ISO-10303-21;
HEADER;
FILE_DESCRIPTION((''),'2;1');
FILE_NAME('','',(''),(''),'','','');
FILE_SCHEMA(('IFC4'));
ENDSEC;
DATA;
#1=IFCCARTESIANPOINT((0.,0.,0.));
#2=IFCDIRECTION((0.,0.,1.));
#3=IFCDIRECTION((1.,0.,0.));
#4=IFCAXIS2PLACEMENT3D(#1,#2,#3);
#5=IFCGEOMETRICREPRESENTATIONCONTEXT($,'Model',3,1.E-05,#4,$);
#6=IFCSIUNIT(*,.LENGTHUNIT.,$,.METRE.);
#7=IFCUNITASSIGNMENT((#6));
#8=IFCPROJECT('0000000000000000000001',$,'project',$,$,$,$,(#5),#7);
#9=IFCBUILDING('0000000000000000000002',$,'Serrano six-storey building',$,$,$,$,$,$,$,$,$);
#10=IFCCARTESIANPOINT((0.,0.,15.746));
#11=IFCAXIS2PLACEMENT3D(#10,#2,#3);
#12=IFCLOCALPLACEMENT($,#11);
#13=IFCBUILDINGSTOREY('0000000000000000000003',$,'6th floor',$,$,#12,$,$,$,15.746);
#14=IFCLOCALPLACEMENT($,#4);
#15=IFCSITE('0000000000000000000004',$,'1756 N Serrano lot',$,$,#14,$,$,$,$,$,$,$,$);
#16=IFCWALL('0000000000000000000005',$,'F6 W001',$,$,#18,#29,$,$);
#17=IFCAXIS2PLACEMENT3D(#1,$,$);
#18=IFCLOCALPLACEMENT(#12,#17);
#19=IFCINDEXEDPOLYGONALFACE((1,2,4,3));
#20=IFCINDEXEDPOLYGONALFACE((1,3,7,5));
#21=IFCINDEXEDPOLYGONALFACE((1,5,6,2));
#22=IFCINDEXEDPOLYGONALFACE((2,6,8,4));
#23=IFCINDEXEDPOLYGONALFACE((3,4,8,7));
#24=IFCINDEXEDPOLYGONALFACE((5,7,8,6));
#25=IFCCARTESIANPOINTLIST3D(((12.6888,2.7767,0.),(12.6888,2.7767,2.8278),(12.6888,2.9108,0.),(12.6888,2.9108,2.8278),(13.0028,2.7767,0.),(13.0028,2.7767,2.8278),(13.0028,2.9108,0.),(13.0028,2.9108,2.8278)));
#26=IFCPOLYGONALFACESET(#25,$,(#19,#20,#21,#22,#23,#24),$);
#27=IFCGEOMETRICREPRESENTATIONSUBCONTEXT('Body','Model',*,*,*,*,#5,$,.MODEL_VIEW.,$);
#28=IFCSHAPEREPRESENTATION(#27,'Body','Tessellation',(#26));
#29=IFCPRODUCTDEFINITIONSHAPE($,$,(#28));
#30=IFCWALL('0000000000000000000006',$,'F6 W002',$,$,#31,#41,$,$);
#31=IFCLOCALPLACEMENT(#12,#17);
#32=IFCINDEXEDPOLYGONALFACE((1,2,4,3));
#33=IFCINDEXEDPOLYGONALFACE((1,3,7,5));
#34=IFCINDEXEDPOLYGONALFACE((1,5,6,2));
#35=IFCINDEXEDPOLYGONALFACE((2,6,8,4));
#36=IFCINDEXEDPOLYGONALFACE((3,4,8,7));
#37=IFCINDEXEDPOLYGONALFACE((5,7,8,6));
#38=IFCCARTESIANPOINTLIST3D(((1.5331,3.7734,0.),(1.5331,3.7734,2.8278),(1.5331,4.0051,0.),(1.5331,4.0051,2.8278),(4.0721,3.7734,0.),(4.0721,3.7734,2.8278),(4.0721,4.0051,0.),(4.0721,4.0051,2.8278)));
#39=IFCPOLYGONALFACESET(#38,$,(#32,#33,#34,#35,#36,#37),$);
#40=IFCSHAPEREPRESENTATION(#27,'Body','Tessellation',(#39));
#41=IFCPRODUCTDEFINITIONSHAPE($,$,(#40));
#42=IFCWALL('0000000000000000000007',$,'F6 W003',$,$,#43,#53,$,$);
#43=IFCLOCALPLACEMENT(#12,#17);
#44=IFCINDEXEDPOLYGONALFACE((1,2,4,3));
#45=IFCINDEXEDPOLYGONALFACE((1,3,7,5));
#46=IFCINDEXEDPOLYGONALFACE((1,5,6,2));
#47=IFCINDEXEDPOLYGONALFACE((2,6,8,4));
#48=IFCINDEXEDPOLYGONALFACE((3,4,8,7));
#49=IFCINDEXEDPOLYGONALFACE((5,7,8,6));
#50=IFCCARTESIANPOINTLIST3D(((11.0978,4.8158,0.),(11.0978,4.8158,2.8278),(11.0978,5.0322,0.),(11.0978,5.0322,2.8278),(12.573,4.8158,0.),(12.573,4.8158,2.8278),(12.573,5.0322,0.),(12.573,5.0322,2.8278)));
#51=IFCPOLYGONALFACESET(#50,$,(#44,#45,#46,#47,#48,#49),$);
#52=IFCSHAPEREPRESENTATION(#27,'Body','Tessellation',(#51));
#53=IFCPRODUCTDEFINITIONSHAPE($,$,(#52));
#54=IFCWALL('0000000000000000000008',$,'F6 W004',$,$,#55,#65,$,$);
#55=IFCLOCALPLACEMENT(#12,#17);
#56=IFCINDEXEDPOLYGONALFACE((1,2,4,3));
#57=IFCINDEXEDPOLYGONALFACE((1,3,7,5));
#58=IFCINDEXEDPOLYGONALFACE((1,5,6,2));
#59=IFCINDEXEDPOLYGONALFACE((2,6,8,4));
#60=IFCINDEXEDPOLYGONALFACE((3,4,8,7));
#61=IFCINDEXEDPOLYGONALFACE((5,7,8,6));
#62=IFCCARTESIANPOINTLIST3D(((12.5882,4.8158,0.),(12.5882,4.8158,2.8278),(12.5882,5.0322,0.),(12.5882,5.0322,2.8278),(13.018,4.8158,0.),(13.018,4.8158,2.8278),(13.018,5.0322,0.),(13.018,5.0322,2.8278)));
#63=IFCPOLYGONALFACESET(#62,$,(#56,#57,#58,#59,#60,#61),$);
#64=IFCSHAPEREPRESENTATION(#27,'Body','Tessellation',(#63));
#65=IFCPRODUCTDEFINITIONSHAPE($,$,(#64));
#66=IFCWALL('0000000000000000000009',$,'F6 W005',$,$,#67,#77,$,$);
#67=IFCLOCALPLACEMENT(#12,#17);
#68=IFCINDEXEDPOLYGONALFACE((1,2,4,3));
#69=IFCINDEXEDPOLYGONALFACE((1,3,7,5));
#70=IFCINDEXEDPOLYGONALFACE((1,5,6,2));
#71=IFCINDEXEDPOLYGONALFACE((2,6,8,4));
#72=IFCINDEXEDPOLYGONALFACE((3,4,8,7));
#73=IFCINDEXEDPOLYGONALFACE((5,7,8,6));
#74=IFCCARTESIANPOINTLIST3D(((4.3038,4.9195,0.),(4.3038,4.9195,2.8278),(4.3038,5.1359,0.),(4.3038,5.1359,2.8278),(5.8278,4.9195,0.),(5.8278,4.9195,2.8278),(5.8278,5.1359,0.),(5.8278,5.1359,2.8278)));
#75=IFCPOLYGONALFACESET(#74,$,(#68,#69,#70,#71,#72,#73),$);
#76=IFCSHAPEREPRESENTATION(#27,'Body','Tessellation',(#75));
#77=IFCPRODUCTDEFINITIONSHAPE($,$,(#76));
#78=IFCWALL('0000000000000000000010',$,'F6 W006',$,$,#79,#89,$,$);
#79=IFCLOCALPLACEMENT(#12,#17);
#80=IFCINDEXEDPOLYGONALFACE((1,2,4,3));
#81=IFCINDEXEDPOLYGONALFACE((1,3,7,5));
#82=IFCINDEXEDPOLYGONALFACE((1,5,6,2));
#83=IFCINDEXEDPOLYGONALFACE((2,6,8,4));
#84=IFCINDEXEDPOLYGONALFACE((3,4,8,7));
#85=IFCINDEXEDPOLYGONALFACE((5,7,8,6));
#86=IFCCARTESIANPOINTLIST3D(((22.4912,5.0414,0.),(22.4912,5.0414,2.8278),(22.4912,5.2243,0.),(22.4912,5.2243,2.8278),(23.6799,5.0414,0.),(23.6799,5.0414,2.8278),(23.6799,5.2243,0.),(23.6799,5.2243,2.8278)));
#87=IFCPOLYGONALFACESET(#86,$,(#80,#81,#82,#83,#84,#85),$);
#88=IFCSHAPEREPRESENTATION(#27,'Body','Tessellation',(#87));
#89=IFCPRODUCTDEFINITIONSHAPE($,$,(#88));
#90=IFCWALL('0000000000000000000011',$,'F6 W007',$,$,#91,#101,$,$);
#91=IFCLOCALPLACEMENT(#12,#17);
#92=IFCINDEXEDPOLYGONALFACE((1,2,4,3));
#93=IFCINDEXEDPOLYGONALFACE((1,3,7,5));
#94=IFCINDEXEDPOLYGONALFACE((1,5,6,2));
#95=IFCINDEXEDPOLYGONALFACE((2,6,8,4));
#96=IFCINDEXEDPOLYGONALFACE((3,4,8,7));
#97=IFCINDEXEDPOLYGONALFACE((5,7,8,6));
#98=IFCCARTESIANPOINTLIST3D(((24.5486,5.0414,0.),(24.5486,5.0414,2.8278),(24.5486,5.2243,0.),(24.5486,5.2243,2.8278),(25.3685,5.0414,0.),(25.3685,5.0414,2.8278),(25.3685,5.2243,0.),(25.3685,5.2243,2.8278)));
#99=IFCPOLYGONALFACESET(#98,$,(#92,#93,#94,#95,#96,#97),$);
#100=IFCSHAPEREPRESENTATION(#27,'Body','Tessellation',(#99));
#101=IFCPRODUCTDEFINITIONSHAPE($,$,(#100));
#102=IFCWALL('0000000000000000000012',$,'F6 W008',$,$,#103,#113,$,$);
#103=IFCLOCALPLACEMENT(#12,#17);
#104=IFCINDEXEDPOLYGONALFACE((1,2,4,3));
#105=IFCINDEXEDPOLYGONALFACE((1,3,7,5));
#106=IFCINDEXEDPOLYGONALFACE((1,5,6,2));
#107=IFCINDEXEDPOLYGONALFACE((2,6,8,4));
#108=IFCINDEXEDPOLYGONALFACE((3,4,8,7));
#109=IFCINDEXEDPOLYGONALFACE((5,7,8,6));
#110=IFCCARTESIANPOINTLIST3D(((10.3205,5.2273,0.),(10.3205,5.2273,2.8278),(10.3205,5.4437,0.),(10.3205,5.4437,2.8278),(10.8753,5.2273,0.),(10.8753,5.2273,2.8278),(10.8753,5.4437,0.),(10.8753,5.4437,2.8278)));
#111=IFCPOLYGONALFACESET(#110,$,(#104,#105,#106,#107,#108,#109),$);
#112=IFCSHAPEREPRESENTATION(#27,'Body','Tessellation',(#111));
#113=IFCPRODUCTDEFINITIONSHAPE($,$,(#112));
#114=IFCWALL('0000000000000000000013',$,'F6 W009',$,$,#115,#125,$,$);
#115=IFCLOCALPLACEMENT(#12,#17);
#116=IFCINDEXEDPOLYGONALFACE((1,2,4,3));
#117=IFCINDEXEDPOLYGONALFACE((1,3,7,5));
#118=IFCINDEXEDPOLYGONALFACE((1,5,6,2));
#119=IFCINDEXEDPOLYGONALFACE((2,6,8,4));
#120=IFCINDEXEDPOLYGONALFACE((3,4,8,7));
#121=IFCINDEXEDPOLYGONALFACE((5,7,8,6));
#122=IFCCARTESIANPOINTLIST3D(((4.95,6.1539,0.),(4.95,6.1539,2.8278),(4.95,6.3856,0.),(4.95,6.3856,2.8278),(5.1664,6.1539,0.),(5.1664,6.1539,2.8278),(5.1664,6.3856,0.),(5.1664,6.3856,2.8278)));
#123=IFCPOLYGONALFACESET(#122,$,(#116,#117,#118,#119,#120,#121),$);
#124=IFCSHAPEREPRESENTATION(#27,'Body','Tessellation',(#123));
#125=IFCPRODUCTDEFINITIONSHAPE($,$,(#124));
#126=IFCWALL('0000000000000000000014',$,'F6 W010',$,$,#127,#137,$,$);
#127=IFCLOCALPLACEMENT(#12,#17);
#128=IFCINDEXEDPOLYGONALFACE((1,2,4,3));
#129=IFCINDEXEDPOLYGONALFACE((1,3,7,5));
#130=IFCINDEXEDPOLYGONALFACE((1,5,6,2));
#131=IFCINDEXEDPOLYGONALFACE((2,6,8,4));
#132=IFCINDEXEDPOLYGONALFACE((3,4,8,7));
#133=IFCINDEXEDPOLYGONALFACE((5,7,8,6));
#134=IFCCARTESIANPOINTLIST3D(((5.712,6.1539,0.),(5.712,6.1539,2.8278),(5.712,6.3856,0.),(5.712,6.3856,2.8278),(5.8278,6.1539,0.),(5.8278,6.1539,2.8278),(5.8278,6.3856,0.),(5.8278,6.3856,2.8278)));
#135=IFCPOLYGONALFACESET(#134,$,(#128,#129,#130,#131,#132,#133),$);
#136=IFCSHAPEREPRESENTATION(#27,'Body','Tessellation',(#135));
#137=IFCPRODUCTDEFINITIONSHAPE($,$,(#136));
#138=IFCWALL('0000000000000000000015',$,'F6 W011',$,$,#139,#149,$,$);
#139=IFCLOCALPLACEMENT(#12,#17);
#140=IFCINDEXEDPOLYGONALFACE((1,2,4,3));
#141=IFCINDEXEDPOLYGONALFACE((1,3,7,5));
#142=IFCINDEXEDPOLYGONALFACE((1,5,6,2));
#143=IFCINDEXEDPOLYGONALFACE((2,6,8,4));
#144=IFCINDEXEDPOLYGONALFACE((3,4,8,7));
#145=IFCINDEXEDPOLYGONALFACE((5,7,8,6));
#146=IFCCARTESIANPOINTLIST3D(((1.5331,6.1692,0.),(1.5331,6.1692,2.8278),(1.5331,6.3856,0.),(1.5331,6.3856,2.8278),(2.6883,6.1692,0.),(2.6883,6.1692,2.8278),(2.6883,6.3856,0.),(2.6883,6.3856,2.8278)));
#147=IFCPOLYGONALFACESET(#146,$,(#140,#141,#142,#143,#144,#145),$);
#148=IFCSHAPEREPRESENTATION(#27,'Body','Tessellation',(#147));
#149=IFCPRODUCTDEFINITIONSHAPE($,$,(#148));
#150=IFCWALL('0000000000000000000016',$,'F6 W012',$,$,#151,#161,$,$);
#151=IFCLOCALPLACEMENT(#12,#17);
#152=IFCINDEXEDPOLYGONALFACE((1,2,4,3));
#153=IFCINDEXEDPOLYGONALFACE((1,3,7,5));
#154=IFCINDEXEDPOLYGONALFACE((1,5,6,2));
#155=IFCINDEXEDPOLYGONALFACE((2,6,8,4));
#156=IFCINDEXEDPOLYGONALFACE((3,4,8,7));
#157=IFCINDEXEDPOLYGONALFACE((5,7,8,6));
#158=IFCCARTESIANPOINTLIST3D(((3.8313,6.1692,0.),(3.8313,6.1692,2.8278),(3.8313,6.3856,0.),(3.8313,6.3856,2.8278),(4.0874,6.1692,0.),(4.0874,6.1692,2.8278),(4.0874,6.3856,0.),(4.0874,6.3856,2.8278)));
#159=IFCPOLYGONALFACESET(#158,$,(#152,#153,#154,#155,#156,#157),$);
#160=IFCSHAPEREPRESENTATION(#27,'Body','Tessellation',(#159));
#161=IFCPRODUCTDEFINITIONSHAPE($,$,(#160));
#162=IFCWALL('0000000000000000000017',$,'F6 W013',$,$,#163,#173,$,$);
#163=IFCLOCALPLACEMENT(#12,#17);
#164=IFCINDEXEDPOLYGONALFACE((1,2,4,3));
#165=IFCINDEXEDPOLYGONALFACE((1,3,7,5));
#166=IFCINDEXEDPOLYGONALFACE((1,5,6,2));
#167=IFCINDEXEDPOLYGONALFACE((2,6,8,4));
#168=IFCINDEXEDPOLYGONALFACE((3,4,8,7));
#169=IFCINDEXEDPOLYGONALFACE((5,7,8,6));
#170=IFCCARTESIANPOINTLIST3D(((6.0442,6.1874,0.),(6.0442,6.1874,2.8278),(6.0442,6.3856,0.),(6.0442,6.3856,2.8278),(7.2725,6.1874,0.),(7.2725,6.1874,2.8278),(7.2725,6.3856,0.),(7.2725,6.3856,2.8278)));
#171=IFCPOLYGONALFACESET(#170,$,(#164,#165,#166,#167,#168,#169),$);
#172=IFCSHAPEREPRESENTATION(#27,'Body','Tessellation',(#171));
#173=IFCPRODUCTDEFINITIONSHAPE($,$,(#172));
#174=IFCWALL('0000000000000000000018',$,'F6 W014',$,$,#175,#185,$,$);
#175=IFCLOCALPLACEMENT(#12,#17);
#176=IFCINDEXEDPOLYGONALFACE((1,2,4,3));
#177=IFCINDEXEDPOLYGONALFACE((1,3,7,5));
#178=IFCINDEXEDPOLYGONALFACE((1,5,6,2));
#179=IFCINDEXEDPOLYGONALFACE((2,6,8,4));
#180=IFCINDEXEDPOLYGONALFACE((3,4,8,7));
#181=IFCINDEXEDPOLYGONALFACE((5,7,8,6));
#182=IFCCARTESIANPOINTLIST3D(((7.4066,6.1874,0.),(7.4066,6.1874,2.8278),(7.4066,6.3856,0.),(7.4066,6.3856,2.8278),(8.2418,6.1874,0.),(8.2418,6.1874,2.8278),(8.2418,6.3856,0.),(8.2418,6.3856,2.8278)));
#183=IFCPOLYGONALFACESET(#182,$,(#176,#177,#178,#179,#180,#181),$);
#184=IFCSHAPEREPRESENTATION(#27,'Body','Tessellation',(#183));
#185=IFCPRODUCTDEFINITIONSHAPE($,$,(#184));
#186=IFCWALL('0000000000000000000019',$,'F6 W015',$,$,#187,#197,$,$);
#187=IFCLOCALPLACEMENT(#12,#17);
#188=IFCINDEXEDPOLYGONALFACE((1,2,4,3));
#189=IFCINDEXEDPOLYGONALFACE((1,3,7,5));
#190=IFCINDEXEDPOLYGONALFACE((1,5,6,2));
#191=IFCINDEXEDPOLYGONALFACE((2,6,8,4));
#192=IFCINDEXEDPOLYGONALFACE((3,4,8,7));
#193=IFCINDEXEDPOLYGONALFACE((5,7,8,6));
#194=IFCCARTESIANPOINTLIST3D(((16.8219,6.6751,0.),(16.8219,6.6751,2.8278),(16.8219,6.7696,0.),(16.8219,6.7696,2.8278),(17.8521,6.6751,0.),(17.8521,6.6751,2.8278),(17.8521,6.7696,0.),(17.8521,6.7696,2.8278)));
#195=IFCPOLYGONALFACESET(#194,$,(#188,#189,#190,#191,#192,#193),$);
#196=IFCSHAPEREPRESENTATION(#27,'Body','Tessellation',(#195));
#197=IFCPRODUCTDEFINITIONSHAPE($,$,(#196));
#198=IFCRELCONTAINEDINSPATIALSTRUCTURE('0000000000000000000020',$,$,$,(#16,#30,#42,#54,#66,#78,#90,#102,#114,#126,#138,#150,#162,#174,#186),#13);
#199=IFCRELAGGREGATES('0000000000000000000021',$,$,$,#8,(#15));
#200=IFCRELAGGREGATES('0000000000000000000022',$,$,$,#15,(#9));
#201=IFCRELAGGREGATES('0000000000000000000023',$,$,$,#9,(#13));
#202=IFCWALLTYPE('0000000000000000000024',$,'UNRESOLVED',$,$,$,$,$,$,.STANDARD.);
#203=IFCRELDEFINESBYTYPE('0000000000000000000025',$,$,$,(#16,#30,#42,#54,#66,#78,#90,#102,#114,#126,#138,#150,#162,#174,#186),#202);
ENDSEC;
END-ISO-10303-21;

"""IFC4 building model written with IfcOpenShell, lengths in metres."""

from ifc_helpers import new_model, si_unit, frame, origin_with_axes, place, context, subcontext, project, spatial, polyline, outline, extrude, type_object, element, save


model = new_model("IFC4")

# Units and contexts
model_context = context("Model", 3, precision=1e-05, world=origin_with_axes())
body_context = subcontext(model_context, "Body", "Model", "MODEL_VIEW")
ifc_project = project(units=[si_unit("LENGTHUNIT", "METRE")], contexts=[model_context])

# Site, building, storey
site_placement = place(None, origin_with_axes())
site = spatial("IfcSite", under=ifc_project, at=site_placement, Name="1756 N Serrano lot")
building = spatial("IfcBuilding", under=site, Name="Serrano six-storey building")
storey_placement = place(None, frame((0.0, 0.0, 15.746), z_axis=(0.0, 0.0, 1.0), x_axis=(1.0, 0.0, 0.0)))
storey = spatial("IfcBuildingStorey", under=building, at=storey_placement, Name="6th floor", Elevation=15.746)

# Walls
wall_type = type_object("IfcWallType", Name="UNRESOLVED", PredefinedType="STANDARD")
wall_1_placement = place(storey_placement, frame((0.0, 0.0, -15.746), z_axis=(0.0, 0.0, 1.0), x_axis=(1.0, 0.0, 0.0)))
element("IfcWall", 1, at=wall_1_placement, inside=storey, type_object=wall_type, Name="F6 W001", context=body_context, shape_type="SweptSolid", body=[
    extrude(outline(polyline([(13.0028, 2.9108), (13.0028, 2.7767), (12.6888, 2.7767), (12.6888, 2.9108), (13.0028, 2.9108)])), frame((0.0, 0.0, 15.746)), (0.0, 0.0, 1.0), 2.8278),
])
wall_2_placement = place(storey_placement, frame((0.0, 0.0, -15.746), z_axis=(0.0, 0.0, 1.0), x_axis=(1.0, 0.0, 0.0)))
element("IfcWall", 2, at=wall_2_placement, inside=storey, type_object=wall_type, Name="F6 W002", context=body_context, shape_type="SweptSolid", body=[
    extrude(outline(polyline([(4.0721, 4.0051), (4.0721, 3.7734), (1.5331, 3.7734), (1.5331, 4.0051), (4.0721, 4.0051)])), frame((0.0, 0.0, 15.746)), (0.0, 0.0, 1.0), 2.8278),
])
wall_3_placement = place(storey_placement, frame((0.0, 0.0, -15.746), z_axis=(0.0, 0.0, 1.0), x_axis=(1.0, 0.0, 0.0)))
element("IfcWall", 3, at=wall_3_placement, inside=storey, type_object=wall_type, Name="F6 W003", context=body_context, shape_type="SweptSolid", body=[
    extrude(outline(polyline([(12.573, 5.0322), (12.573, 4.8158), (11.0978, 4.8158), (11.0978, 5.0322), (12.573, 5.0322)])), frame((0.0, 0.0, 15.746)), (0.0, 0.0, 1.0), 2.8278),
])
wall_4_placement = place(storey_placement, frame((0.0, 0.0, -15.746), z_axis=(0.0, 0.0, 1.0), x_axis=(1.0, 0.0, 0.0)))
element("IfcWall", 4, at=wall_4_placement, inside=storey, type_object=wall_type, Name="F6 W004", context=body_context, shape_type="SweptSolid", body=[
    extrude(outline(polyline([(13.018, 5.0322), (13.018, 4.8158), (12.5882, 4.8158), (12.5882, 5.0322), (13.018, 5.0322)])), frame((0.0, 0.0, 15.746)), (0.0, 0.0, 1.0), 2.8278),
])
wall_5_placement = place(storey_placement, frame((0.0, 0.0, -15.746), z_axis=(0.0, 0.0, 1.0), x_axis=(1.0, 0.0, 0.0)))
element("IfcWall", 5, at=wall_5_placement, inside=storey, type_object=wall_type, Name="F6 W005", context=body_context, shape_type="SweptSolid", body=[
    extrude(outline(polyline([(5.8278, 5.1359), (5.8278, 4.9195), (4.3038, 4.9195), (4.3038, 5.1359), (5.8278, 5.1359)])), frame((0.0, 0.0, 15.746)), (0.0, 0.0, 1.0), 2.8278),
])
wall_6_placement = place(storey_placement, frame((0.0, 0.0, -15.746), z_axis=(0.0, 0.0, 1.0), x_axis=(1.0, 0.0, 0.0)))
element("IfcWall", 6, at=wall_6_placement, inside=storey, type_object=wall_type, Name="F6 W006", context=body_context, shape_type="SweptSolid", body=[
    extrude(outline(polyline([(23.6799, 5.2243), (23.6799, 5.0414), (22.4912, 5.0414), (22.4912, 5.2243), (23.6799, 5.2243)])), frame((0.0, 0.0, 15.746)), (0.0, 0.0, 1.0), 2.8278),
])
wall_7_placement = place(storey_placement, frame((0.0, 0.0, -15.746), z_axis=(0.0, 0.0, 1.0), x_axis=(1.0, 0.0, 0.0)))
element("IfcWall", 7, at=wall_7_placement, inside=storey, type_object=wall_type, Name="F6 W007", context=body_context, shape_type="SweptSolid", body=[
    extrude(outline(polyline([(25.3685, 5.2243), (25.3685, 5.0414), (24.5486, 5.0414), (24.5486, 5.2243), (25.3685, 5.2243)])), frame((0.0, 0.0, 15.746)), (0.0, 0.0, 1.0), 2.8278),
])
wall_8_placement = place(storey_placement, frame((0.0, 0.0, -15.746), z_axis=(0.0, 0.0, 1.0), x_axis=(1.0, 0.0, 0.0)))
element("IfcWall", 8, at=wall_8_placement, inside=storey, type_object=wall_type, Name="F6 W008", context=body_context, shape_type="SweptSolid", body=[
    extrude(outline(polyline([(10.8753, 5.4437), (10.8753, 5.2273), (10.3205, 5.2273), (10.3205, 5.4437), (10.8753, 5.4437)])), frame((0.0, 0.0, 15.746)), (0.0, 0.0, 1.0), 2.8278),
])
wall_9_placement = place(storey_placement, frame((0.0, 0.0, -15.746), z_axis=(0.0, 0.0, 1.0), x_axis=(1.0, 0.0, 0.0)))
element("IfcWall", 9, at=wall_9_placement, inside=storey, type_object=wall_type, Name="F6 W009", context=body_context, shape_type="SweptSolid", body=[
    extrude(outline(polyline([(5.1664, 6.3856), (5.1664, 6.1539), (4.95, 6.1539), (4.95, 6.3856), (5.1664, 6.3856)])), frame((0.0, 0.0, 15.746)), (0.0, 0.0, 1.0), 2.8278),
])
wall_10_placement = place(storey_placement, frame((0.0, 0.0, -15.746), z_axis=(0.0, 0.0, 1.0), x_axis=(1.0, 0.0, 0.0)))
element("IfcWall", 10, at=wall_10_placement, inside=storey, type_object=wall_type, Name="F6 W010", context=body_context, shape_type="SweptSolid", body=[
    extrude(outline(polyline([(5.8278, 6.3856), (5.8278, 6.1539), (5.712, 6.1539), (5.712, 6.3856), (5.8278, 6.3856)])), frame((0.0, 0.0, 15.746)), (0.0, 0.0, 1.0), 2.8278),
])
wall_11_placement = place(storey_placement, frame((0.0, 0.0, -15.746), z_axis=(0.0, 0.0, 1.0), x_axis=(1.0, 0.0, 0.0)))
element("IfcWall", 11, at=wall_11_placement, inside=storey, type_object=wall_type, Name="F6 W011", context=body_context, shape_type="SweptSolid", body=[
    extrude(outline(polyline([(2.6883, 6.3856), (2.6883, 6.1692), (1.5331, 6.1692), (1.5331, 6.3856), (2.6883, 6.3856)])), frame((0.0, 0.0, 15.746)), (0.0, 0.0, 1.0), 2.8278),
])
wall_12_placement = place(storey_placement, frame((0.0, 0.0, -15.746), z_axis=(0.0, 0.0, 1.0), x_axis=(1.0, 0.0, 0.0)))
element("IfcWall", 12, at=wall_12_placement, inside=storey, type_object=wall_type, Name="F6 W012", context=body_context, shape_type="SweptSolid", body=[
    extrude(outline(polyline([(4.0874, 6.3856), (4.0874, 6.1692), (3.8313, 6.1692), (3.8313, 6.3856), (4.0874, 6.3856)])), frame((0.0, 0.0, 15.746)), (0.0, 0.0, 1.0), 2.8278),
])
wall_13_placement = place(storey_placement, frame((0.0, 0.0, -15.746), z_axis=(0.0, 0.0, 1.0), x_axis=(1.0, 0.0, 0.0)))
element("IfcWall", 13, at=wall_13_placement, inside=storey, type_object=wall_type, Name="F6 W013", context=body_context, shape_type="SweptSolid", body=[
    extrude(outline(polyline([(7.2725, 6.3856), (7.2725, 6.1874), (6.0442, 6.1874), (6.0442, 6.3856), (7.2725, 6.3856)])), frame((0.0, 0.0, 15.746)), (0.0, 0.0, 1.0), 2.8278),
])
wall_14_placement = place(storey_placement, frame((0.0, 0.0, -15.746), z_axis=(0.0, 0.0, 1.0), x_axis=(1.0, 0.0, 0.0)))
element("IfcWall", 14, at=wall_14_placement, inside=storey, type_object=wall_type, Name="F6 W014", context=body_context, shape_type="SweptSolid", body=[
    extrude(outline(polyline([(8.2418, 6.3856), (8.2418, 6.1874), (7.4066, 6.1874), (7.4066, 6.3856), (8.2418, 6.3856)])), frame((0.0, 0.0, 15.746)), (0.0, 0.0, 1.0), 2.8278),
])
wall_15_placement = place(storey_placement, frame((0.0, 0.0, -15.746), z_axis=(0.0, 0.0, 1.0), x_axis=(1.0, 0.0, 0.0)))
element("IfcWall", 15, at=wall_15_placement, inside=storey, type_object=wall_type, Name="F6 W015", context=body_context, shape_type="SweptSolid", body=[
    extrude(outline(polyline([(17.8521, 6.7696), (17.8521, 6.6751), (16.8219, 6.6751), (16.8219, 6.7696), (17.8521, 6.7696)])), frame((0.0, 0.0, 15.746)), (0.0, 0.0, 1.0), 2.8278),
])

save(model, "model.ifc")
